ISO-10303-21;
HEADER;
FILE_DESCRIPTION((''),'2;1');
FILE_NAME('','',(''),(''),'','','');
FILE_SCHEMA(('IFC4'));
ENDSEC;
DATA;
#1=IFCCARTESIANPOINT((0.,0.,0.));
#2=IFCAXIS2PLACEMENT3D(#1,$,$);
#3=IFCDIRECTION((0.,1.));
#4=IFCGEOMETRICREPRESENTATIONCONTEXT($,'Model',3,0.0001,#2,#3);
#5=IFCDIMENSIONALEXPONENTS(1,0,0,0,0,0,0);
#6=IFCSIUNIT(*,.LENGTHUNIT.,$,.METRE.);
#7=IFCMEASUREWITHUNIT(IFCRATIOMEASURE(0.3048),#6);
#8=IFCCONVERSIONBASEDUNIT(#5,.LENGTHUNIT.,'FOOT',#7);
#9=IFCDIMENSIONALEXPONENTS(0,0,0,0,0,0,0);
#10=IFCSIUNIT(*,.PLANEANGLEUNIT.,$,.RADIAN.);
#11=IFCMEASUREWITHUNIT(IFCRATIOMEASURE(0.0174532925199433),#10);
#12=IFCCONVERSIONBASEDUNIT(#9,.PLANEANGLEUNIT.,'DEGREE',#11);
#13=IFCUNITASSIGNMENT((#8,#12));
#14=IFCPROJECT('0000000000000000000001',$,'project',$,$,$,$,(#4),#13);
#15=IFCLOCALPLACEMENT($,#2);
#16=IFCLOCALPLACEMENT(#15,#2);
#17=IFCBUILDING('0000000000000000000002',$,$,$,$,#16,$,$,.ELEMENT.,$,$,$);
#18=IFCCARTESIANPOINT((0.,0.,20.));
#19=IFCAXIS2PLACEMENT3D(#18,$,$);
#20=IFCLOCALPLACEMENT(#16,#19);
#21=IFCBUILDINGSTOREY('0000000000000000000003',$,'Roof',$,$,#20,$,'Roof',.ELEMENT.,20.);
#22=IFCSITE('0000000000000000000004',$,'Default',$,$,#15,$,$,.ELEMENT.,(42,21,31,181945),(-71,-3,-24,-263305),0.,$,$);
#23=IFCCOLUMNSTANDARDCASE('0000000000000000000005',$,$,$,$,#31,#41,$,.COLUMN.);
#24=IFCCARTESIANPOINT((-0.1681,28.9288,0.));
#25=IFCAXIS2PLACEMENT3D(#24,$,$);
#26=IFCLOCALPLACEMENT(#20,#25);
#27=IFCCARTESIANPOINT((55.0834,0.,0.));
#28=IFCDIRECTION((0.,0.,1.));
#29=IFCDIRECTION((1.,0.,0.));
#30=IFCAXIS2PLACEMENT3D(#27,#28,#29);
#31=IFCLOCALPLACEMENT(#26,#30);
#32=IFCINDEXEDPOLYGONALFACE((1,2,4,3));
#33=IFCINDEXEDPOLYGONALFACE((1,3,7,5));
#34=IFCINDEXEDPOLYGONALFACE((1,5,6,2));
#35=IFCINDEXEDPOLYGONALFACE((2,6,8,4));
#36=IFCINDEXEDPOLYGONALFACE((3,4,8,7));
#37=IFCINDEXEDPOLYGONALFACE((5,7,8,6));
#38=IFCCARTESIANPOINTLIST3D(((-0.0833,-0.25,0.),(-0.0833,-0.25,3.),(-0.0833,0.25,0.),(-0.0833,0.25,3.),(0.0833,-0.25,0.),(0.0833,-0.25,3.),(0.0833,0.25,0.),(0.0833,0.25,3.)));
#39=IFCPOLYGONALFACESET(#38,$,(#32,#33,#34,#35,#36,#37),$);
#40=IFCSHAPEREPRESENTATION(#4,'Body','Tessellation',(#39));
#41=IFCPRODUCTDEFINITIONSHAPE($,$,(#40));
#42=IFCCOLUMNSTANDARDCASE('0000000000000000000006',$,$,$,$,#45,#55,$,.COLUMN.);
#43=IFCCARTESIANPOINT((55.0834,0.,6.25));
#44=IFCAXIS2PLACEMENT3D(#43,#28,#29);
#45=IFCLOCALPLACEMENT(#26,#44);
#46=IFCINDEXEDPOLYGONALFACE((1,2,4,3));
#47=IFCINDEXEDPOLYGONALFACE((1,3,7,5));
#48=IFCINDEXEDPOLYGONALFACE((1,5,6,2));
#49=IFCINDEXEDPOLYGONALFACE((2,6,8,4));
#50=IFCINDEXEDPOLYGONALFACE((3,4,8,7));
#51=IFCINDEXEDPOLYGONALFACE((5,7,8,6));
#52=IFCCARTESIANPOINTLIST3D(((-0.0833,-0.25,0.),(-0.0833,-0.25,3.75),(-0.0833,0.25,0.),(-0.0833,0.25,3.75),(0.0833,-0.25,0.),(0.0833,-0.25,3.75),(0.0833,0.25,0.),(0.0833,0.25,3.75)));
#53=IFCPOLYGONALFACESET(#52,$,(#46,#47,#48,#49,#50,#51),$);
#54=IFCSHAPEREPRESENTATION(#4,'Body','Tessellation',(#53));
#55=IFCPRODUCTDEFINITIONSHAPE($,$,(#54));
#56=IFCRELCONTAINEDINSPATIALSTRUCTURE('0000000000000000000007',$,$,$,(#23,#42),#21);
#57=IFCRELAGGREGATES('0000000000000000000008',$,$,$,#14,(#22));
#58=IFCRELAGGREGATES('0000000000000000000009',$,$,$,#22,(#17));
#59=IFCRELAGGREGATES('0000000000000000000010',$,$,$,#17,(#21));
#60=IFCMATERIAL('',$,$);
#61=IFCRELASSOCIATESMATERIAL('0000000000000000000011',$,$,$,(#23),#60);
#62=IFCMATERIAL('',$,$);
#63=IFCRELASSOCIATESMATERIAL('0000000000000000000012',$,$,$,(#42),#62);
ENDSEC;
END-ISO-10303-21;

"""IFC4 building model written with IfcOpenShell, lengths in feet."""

from ifc_helpers import new_model, entity, si_unit, converted_unit, direction, frame, origin, place, context, project, spatial, rectangle, extrude, material, element, save


model = new_model("IFC4")

# Units and contexts
model_context = context("Model", 3, precision=0.0001, world=origin(), true_north=direction((0.0, 1.0)))
ifc_project = project(units=[converted_unit("LENGTHUNIT", "FOOT", entity("IfcRatioMeasure", 0.3048), si_unit("LENGTHUNIT", "METRE"), dimensions=[1, 0, 0, 0, 0, 0, 0]), converted_unit("PLANEANGLEUNIT", "DEGREE", entity("IfcRatioMeasure", 0.0174532925199433), si_unit("PLANEANGLEUNIT", "RADIAN"), dimensions=[0, 0, 0, 0, 0, 0, 0])], contexts=[model_context])

# Site, building, storey
site_placement = place(None, origin())
site = spatial("IfcSite", under=ifc_project, at=site_placement, Name="Default", CompositionType="ELEMENT", RefLatitude=(42, 21, 31, 181945), RefLongitude=(-71, -3, -24, -263305), RefElevation=0.0)
building_placement = place(site_placement, origin())
building = spatial("IfcBuilding", under=site, at=building_placement, CompositionType="ELEMENT")
storey_placement = place(building_placement, frame((0.0, 0.0, 20.0)))
storey = spatial("IfcBuildingStorey", under=building, at=storey_placement, Name="Roof", LongName="Roof", CompositionType="ELEMENT", Elevation=20.0)

# Columns
ifc_material_1 = material(Name="")
placement = place(storey_placement, frame((-0.1681, 28.9288, 0.0)))
for number, where, z_axis, x_axis in (
    (1, (55.0834, 0.0, 0.0), (0.0, 0.0, 1.0), (1.0, 0.0, 0.0)),
):
    element("IfcColumnStandardCase", number, at=place(placement, frame(where, z_axis=z_axis, x_axis=x_axis)), inside=storey, material=ifc_material_1, PredefinedType="COLUMN", context=model_context, shape_type="SweptSolid", body=[
        extrude(rectangle(XDim=0.1667, YDim=0.5), origin(), (0.0, 0.0, 1.0), 3.0),
    ])
ifc_material_2 = material(Name="")
for number, where, z_axis, x_axis in (
    (2, (55.0834, 0.0, 6.25), (0.0, 0.0, 1.0), (1.0, 0.0, 0.0)),
):
    element("IfcColumnStandardCase", number, at=place(placement, frame(where, z_axis=z_axis, x_axis=x_axis)), inside=storey, material=ifc_material_2, PredefinedType="COLUMN", context=model_context, shape_type="SweptSolid", body=[
        extrude(rectangle(XDim=0.1667, YDim=0.5), origin(), (0.0, 0.0, 1.0), 3.75),
    ])

save(model, "model.ifc")
